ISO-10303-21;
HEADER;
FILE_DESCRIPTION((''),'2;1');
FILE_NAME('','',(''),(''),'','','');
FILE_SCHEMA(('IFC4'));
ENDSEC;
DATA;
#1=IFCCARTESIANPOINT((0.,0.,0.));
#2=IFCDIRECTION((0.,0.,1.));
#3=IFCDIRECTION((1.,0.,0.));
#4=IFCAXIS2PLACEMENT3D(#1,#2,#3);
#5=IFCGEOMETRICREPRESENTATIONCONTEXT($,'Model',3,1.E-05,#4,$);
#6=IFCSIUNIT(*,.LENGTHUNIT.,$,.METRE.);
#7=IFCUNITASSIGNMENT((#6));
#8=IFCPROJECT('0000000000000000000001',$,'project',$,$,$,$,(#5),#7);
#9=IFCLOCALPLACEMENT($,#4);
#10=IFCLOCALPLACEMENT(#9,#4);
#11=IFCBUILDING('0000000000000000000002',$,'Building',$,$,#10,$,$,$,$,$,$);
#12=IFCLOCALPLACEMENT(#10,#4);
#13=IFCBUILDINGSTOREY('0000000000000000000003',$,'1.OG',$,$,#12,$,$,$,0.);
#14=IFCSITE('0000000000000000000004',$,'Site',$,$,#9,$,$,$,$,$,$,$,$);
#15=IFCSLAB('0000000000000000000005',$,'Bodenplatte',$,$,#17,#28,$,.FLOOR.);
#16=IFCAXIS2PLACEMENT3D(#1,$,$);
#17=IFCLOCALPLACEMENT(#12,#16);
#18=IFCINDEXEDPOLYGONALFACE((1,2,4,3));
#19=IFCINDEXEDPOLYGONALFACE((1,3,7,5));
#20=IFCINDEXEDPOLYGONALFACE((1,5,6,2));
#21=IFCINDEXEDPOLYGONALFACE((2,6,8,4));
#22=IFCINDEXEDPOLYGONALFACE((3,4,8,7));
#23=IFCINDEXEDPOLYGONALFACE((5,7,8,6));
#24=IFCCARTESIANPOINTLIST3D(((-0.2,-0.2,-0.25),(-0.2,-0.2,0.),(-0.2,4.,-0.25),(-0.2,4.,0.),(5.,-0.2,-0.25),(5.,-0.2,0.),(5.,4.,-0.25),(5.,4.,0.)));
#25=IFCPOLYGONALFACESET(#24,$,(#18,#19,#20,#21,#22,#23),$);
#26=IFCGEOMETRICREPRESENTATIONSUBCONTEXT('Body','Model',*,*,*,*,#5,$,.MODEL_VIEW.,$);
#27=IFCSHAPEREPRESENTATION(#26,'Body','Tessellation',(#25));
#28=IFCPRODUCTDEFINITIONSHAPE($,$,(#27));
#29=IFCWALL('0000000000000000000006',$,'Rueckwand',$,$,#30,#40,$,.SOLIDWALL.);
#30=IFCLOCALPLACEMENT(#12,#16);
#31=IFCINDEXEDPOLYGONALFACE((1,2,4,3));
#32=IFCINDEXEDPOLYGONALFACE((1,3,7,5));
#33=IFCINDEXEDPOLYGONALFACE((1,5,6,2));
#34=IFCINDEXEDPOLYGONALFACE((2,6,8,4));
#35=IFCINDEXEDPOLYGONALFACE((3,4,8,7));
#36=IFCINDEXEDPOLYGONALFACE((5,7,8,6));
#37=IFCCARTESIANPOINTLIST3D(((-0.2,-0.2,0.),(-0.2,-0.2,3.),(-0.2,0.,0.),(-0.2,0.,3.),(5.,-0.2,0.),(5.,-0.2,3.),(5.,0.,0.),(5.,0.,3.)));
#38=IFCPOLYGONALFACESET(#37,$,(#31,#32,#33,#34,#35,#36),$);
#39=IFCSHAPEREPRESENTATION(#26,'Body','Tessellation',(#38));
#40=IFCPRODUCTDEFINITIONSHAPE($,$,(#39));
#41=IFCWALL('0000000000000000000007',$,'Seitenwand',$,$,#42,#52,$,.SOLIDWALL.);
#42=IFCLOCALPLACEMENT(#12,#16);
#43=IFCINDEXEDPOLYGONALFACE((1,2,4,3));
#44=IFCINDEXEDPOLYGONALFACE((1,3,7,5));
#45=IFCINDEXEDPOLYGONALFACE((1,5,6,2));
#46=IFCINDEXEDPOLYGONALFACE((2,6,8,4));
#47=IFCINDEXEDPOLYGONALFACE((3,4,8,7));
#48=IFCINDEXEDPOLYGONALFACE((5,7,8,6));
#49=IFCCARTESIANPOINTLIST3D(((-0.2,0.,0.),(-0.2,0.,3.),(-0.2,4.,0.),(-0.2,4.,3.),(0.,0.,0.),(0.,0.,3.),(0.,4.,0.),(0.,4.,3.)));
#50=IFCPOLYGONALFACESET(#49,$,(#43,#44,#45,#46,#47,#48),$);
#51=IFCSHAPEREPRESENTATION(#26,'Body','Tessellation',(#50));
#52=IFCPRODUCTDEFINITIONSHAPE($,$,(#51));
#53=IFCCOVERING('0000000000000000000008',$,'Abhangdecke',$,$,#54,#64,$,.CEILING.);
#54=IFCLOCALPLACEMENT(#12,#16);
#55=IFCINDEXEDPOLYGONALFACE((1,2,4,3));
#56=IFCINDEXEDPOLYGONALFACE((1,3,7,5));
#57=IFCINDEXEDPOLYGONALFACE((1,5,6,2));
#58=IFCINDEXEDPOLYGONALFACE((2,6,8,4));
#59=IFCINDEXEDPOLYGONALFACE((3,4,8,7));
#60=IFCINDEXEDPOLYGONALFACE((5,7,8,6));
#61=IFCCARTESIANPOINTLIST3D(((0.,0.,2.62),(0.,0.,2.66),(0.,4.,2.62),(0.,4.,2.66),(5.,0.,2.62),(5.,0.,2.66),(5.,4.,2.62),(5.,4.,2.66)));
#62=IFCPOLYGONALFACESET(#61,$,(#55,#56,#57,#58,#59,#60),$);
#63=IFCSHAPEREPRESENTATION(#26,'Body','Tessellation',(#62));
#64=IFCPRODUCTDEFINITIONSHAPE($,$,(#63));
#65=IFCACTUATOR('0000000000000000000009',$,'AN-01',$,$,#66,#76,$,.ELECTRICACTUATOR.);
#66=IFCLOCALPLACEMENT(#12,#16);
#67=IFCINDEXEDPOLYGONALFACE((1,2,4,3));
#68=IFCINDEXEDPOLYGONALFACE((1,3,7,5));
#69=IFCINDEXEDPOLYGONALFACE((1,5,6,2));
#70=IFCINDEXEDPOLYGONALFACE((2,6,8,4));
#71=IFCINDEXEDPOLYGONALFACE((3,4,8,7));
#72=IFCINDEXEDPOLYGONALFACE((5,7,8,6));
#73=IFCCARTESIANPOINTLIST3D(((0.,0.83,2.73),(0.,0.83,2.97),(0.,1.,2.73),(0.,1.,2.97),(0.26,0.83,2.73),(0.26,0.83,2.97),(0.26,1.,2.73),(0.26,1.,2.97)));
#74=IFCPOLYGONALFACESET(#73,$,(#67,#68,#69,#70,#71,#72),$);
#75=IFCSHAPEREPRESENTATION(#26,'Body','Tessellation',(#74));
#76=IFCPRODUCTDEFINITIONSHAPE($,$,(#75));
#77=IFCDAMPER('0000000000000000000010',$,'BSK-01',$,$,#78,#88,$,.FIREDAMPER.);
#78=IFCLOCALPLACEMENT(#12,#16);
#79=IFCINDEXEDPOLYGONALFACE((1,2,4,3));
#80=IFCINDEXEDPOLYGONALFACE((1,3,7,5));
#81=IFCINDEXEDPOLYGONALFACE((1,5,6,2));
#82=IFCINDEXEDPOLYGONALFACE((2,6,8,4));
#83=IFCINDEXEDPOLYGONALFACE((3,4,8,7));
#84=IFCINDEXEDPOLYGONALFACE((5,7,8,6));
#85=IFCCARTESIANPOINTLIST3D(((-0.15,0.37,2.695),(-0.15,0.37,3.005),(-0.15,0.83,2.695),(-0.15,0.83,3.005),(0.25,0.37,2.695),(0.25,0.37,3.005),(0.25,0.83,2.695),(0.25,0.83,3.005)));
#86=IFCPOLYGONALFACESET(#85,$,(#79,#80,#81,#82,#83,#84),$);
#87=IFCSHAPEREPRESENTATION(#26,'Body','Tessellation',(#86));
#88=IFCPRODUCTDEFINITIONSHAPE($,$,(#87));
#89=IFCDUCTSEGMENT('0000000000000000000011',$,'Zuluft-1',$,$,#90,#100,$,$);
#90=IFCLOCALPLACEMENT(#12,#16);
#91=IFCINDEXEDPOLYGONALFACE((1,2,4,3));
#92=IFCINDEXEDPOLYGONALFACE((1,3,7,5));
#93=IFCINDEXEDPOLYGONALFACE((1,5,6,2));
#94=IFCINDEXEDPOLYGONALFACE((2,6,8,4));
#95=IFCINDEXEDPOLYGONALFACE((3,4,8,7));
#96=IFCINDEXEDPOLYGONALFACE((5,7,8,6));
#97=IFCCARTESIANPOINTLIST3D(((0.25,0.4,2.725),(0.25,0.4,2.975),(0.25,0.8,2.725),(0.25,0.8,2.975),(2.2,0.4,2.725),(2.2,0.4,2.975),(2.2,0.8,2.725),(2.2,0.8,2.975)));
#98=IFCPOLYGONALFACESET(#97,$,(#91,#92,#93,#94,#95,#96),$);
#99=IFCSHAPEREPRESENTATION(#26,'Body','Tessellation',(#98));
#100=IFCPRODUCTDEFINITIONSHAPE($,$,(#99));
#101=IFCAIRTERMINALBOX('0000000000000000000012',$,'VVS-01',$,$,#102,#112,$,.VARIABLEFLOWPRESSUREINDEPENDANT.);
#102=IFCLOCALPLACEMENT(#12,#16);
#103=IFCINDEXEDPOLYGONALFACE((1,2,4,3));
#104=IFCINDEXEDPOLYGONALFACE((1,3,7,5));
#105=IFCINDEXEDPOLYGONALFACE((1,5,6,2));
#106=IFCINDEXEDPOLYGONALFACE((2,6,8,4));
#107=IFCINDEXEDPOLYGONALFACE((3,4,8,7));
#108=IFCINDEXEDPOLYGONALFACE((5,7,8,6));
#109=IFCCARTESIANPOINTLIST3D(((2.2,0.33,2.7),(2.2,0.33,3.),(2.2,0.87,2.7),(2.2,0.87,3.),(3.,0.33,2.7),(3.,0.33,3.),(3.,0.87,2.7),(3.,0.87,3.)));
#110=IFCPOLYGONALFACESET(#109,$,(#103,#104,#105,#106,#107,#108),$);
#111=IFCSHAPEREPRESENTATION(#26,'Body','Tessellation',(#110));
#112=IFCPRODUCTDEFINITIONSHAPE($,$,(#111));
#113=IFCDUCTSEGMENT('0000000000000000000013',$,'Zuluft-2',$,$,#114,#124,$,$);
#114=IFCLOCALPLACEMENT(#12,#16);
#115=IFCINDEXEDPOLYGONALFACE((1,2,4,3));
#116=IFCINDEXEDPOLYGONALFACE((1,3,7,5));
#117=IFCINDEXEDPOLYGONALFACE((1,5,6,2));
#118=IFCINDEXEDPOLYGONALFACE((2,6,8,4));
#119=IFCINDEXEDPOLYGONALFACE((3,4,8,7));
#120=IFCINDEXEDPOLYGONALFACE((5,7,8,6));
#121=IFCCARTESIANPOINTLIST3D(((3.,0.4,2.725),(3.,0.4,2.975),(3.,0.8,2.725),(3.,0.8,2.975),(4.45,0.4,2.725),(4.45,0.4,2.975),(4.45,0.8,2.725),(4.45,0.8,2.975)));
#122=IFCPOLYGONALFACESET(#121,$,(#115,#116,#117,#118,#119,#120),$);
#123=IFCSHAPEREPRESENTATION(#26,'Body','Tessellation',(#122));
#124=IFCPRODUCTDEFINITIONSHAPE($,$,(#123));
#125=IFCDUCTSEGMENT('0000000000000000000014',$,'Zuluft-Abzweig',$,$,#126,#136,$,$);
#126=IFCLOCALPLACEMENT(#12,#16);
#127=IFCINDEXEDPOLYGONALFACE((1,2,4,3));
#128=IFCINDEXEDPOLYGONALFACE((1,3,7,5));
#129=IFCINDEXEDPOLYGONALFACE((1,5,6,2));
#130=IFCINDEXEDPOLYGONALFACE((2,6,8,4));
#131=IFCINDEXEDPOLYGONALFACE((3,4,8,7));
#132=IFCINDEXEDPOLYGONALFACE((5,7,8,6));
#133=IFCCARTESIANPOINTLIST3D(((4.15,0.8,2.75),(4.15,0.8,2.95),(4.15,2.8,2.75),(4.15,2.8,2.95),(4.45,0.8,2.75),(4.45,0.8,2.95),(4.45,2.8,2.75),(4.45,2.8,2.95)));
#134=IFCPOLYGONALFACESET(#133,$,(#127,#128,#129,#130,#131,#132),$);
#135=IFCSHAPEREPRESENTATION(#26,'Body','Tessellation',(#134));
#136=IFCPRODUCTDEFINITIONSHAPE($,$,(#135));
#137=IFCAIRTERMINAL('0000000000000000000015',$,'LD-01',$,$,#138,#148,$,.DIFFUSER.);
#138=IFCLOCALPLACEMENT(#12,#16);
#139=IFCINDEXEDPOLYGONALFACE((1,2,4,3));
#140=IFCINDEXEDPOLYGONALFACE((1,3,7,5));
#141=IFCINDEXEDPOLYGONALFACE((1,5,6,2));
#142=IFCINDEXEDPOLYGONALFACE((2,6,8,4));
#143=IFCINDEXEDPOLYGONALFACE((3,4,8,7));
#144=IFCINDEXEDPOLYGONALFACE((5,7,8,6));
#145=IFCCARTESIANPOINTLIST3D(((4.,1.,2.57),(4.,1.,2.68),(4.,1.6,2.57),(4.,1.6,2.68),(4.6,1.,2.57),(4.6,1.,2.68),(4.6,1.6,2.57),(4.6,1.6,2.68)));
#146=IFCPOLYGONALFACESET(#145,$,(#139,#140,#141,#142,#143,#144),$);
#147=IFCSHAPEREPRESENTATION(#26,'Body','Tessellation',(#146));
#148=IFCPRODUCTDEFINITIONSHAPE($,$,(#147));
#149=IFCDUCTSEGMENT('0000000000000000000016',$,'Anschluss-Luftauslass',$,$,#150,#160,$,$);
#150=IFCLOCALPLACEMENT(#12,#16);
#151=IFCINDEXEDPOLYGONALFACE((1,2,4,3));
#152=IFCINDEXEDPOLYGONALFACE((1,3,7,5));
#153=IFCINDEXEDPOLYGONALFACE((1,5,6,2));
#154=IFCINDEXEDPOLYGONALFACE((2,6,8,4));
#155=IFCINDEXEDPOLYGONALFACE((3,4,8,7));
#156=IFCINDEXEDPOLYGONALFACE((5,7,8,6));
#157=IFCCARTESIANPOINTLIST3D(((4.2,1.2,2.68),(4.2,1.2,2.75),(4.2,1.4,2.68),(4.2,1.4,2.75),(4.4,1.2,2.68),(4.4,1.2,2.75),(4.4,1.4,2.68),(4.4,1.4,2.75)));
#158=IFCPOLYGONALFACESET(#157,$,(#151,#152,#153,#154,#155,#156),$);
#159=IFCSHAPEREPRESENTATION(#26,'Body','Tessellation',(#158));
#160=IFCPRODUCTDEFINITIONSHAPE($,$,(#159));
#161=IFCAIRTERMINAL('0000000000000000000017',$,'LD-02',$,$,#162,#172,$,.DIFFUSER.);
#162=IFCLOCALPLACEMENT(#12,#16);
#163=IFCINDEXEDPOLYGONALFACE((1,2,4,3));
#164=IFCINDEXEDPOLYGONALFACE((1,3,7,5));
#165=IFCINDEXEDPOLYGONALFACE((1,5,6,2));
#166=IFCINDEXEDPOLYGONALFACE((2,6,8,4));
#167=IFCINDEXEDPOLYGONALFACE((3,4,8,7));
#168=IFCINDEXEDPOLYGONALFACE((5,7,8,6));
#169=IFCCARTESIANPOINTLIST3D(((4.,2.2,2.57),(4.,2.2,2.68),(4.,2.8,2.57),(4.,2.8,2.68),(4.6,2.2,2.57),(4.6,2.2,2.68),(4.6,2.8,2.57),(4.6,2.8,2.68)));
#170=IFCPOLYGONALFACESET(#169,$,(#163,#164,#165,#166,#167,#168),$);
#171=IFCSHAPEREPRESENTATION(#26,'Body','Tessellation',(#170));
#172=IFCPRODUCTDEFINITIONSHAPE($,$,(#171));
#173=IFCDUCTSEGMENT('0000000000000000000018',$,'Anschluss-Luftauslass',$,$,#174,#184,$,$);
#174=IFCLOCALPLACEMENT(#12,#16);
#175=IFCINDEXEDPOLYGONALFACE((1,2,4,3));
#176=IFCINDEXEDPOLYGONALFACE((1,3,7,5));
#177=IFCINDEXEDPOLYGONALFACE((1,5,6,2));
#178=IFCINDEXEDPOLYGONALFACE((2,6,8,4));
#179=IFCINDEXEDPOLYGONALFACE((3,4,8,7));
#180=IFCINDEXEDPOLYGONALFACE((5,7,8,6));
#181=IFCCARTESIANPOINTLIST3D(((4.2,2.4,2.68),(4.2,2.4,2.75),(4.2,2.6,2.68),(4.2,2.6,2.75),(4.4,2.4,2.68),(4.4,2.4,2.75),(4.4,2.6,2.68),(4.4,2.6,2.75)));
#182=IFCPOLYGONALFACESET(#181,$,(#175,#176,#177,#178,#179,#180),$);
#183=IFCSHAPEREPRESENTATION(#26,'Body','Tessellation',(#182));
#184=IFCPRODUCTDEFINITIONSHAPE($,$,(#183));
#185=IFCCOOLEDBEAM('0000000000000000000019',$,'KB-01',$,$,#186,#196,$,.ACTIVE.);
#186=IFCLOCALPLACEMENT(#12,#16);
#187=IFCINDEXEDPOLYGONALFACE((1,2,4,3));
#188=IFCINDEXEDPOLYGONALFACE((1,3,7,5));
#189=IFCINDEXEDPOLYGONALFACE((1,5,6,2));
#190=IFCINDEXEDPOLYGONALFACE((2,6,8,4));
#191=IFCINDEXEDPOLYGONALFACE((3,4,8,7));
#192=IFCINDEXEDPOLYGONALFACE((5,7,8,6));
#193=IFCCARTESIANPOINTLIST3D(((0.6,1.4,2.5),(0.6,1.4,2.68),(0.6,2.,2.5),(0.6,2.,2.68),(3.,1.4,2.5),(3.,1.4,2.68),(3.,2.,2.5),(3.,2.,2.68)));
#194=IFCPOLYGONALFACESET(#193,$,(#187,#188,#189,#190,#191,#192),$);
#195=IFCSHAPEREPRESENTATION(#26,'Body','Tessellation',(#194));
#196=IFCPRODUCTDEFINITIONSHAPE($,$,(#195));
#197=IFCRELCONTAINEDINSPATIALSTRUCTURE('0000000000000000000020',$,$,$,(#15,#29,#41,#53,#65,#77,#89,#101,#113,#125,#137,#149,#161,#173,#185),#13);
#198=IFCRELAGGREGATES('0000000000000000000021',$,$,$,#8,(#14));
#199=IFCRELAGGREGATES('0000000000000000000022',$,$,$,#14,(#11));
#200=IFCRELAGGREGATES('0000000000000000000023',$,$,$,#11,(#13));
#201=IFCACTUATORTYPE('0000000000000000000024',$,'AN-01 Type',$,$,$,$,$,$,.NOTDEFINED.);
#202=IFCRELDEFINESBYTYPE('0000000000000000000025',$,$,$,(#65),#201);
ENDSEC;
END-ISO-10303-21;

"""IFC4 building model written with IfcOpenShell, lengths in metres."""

from ifc_helpers import new_model, si_unit, frame, origin_with_axes, place, context, subcontext, project, spatial, polyline, outline, extrude, type_object, element, save


model = new_model("IFC4")

# Units and contexts
model_context = context("Model", 3, precision=1e-05, world=origin_with_axes())
body_context = subcontext(model_context, "Body", "Model", "MODEL_VIEW")
ifc_project = project(units=[si_unit("LENGTHUNIT", "METRE")], contexts=[model_context])

# Site, building, storey
site_placement = place(None, origin_with_axes())
site = spatial("IfcSite", under=ifc_project, at=site_placement, Name="Site")
building_placement = place(site_placement, origin_with_axes())
building = spatial("IfcBuilding", under=site, at=building_placement, Name="Building")
storey_placement = place(building_placement, origin_with_axes())
storey = spatial("IfcBuildingStorey", under=building, at=storey_placement, Name="1.OG", Elevation=0.0)

# Slab
slab_placement = place(storey_placement, frame((0.0, 0.0, -0.25), z_axis=(0.0, 0.0, 1.0), x_axis=(1.0, 0.0, 0.0)))
element("IfcSlab", 1, at=slab_placement, inside=storey, Name="Bodenplatte", PredefinedType="FLOOR", context=body_context, shape_type="SweptSolid", body=[
    extrude(outline(polyline([(-0.2, -0.2, 0.0), (5.0, -0.2, 0.0), (5.0, 4.0, 0.0), (-0.2, 4.0, 0.0), (-0.2, -0.2, 0.0)])), origin_with_axes(), (0.0, 0.0, 1.0), 0.25),
])

# Walls
wall_1_placement = place(storey_placement, frame((-0.2, -0.2, 0.0), z_axis=(0.0, 0.0, 1.0), x_axis=(1.0, 0.0, 0.0)))
element("IfcWall", 2, at=wall_1_placement, inside=storey, Name="Rueckwand", PredefinedType="SOLIDWALL", context=body_context, shape_type="SweptSolid", body=[
    extrude(outline(polyline([(0.0, 0.0, 0.0), (5.2, 0.0, 0.0), (5.2, 0.2, 0.0), (0.0, 0.2, 0.0), (0.0, 0.0, 0.0)])), origin_with_axes(), (0.0, 0.0, 1.0), 3.0),
])
wall_2_placement = place(storey_placement, frame((0.0, 0.0, 0.0), z_axis=(0.0, 0.0, 1.0), x_axis=(0.0, 1.0, 0.0)))
element("IfcWall", 3, at=wall_2_placement, inside=storey, Name="Seitenwand", PredefinedType="SOLIDWALL", context=body_context, shape_type="SweptSolid", body=[
    extrude(outline(polyline([(0.0, 0.0, 0.0), (4.0, 0.0, 0.0), (4.0, 0.2, 0.0), (0.0, 0.2, 0.0), (0.0, 0.0, 0.0)])), origin_with_axes(), (0.0, 0.0, 1.0), 3.0),
])

# Covering
covering_placement = place(storey_placement, frame((0.0, 0.0, 2.62), z_axis=(0.0, 0.0, 1.0), x_axis=(1.0, 0.0, 0.0)))
element("IfcCovering", 4, at=covering_placement, inside=storey, Name="Abhangdecke", PredefinedType="CEILING", context=body_context, shape_type="SweptSolid", body=[
    extrude(outline(polyline([(0.0, 0.0, 0.0), (5.0, 0.0, 0.0), (5.0, 4.0, 0.0), (0.0, 4.0, 0.0), (0.0, 0.0, 0.0)])), origin_with_axes(), (0.0, 0.0, 1.0), 0.04),
])

# Actuator
actuator_type = type_object("IfcActuatorType", Name="AN-01 Type", PredefinedType="NOTDEFINED")
actuator_placement = place(storey_placement, origin_with_axes())
element("IfcActuator", 5, at=actuator_placement, inside=storey, type_object=actuator_type, Name="AN-01", PredefinedType="ELECTRICACTUATOR", context=body_context, shape_type="SweptSolid", body=[
    extrude(outline(polyline([(0.0, 0.83, 0.0), (0.26, 0.83, 0.0), (0.26, 1.0, 0.0), (0.0, 1.0, 0.0), (0.0, 0.83, 0.0)])), frame((0.0, 0.0, 2.73), z_axis=(0.0, 0.0, 1.0), x_axis=(1.0, 0.0, 0.0)), (0.0, 0.0, 1.0), 0.24),
])

# Damper
damper_placement = place(storey_placement, origin_with_axes())
element("IfcDamper", 6, at=damper_placement, inside=storey, Name="BSK-01", PredefinedType="FIREDAMPER", context=body_context, shape_type="SweptSolid", body=[
    extrude(outline(polyline([(-0.15, 0.37, 0.0), (0.25, 0.37, 0.0), (0.25, 0.83, 0.0), (-0.15, 0.83, 0.0), (-0.15, 0.37, 0.0)])), frame((0.0, 0.0, 2.695), z_axis=(0.0, 0.0, 1.0), x_axis=(1.0, 0.0, 0.0)), (0.0, 0.0, 1.0), 0.31),
])

# Duct segment
duct_segment_1_placement = place(storey_placement, origin_with_axes())
element("IfcDuctSegment", 7, at=duct_segment_1_placement, inside=storey, Name="Zuluft-1", context=body_context, shape_type="SweptSolid", body=[
    extrude(outline(polyline([(-0.2, -0.125, 0.0), (0.2, -0.125, 0.0), (0.2, 0.125, 0.0), (-0.2, 0.125, 0.0), (-0.2, -0.125, 0.0)])), frame((0.25, 0.6, 2.85), z_axis=(1.0, 0.0, 0.0), x_axis=(0.0, 1.0, 0.0)), (0.0, 0.0, 1.0), 1.95),
])

# Air terminal box
air_terminal_box_placement = place(storey_placement, origin_with_axes())
element("IfcAirTerminalBox", 8, at=air_terminal_box_placement, inside=storey, Name="VVS-01", PredefinedType="VARIABLEFLOWPRESSUREINDEPENDANT", context=body_context, shape_type="SweptSolid", body=[
    extrude(outline(polyline([(2.2, 0.33, 0.0), (3.0, 0.33, 0.0), (3.0, 0.87, 0.0), (2.2, 0.87, 0.0), (2.2, 0.33, 0.0)])), frame((0.0, 0.0, 2.7), z_axis=(0.0, 0.0, 1.0), x_axis=(1.0, 0.0, 0.0)), (0.0, 0.0, 1.0), 0.3),
])

# Duct segments
duct_segment_2_placement = place(storey_placement, origin_with_axes())
element("IfcDuctSegment", 9, at=duct_segment_2_placement, inside=storey, Name="Zuluft-2", context=body_context, shape_type="SweptSolid", body=[
    extrude(outline(polyline([(-0.2, -0.125, 0.0), (0.2, -0.125, 0.0), (0.2, 0.125, 0.0), (-0.2, 0.125, 0.0), (-0.2, -0.125, 0.0)])), frame((3.0, 0.6, 2.85), z_axis=(1.0, 0.0, 0.0), x_axis=(0.0, 1.0, 0.0)), (0.0, 0.0, 1.0), 1.45),
])
duct_segment_3_placement = place(storey_placement, origin_with_axes())
element("IfcDuctSegment", 10, at=duct_segment_3_placement, inside=storey, Name="Zuluft-Abzweig", context=body_context, shape_type="SweptSolid", body=[
    extrude(outline(polyline([(-0.15, -0.1, 0.0), (0.15, -0.1, 0.0), (0.15, 0.1, 0.0), (-0.15, 0.1, 0.0), (-0.15, -0.1, 0.0)])), frame((4.3, 0.8, 2.85), z_axis=(0.0, 1.0, 0.0), x_axis=(-1.0, 0.0, 0.0)), (0.0, 0.0, 1.0), 2.0),
])

# Air terminal
air_terminal_1_placement = place(storey_placement, origin_with_axes())
element("IfcAirTerminal", 11, at=air_terminal_1_placement, inside=storey, Name="LD-01", PredefinedType="DIFFUSER", context=body_context, shape_type="SweptSolid", body=[
    extrude(outline(polyline([(4.0, 1.0, 0.0), (4.6, 1.0, 0.0), (4.6, 1.6, 0.0), (4.0, 1.6, 0.0), (4.0, 1.0, 0.0)])), frame((0.0, 0.0, 2.57), z_axis=(0.0, 0.0, 1.0), x_axis=(1.0, 0.0, 0.0)), (0.0, 0.0, 1.0), 0.11),
])

# Duct segment
duct_segment_4_placement = place(storey_placement, origin_with_axes())
element("IfcDuctSegment", 12, at=duct_segment_4_placement, inside=storey, Name="Anschluss-Luftauslass", context=body_context, shape_type="SweptSolid", body=[
    extrude(outline(polyline([(-0.1, -0.1, 0.0), (0.1, -0.1, 0.0), (0.1, 0.1, 0.0), (-0.1, 0.1, 0.0), (-0.1, -0.1, 0.0)])), frame((4.3, 1.3, 2.68), z_axis=(0.0, 0.0, 1.0), x_axis=(1.0, 0.0, 0.0)), (0.0, 0.0, 1.0), 0.07),
])

# Air terminal
air_terminal_2_placement = place(storey_placement, origin_with_axes())
element("IfcAirTerminal", 13, at=air_terminal_2_placement, inside=storey, Name="LD-02", PredefinedType="DIFFUSER", context=body_context, shape_type="SweptSolid", body=[
    extrude(outline(polyline([(4.0, 2.2, 0.0), (4.6, 2.2, 0.0), (4.6, 2.8, 0.0), (4.0, 2.8, 0.0), (4.0, 2.2, 0.0)])), frame((0.0, 0.0, 2.57), z_axis=(0.0, 0.0, 1.0), x_axis=(1.0, 0.0, 0.0)), (0.0, 0.0, 1.0), 0.11),
])

# Duct segment
duct_segment_5_placement = place(storey_placement, origin_with_axes())
element("IfcDuctSegment", 14, at=duct_segment_5_placement, inside=storey, Name="Anschluss-Luftauslass", context=body_context, shape_type="SweptSolid", body=[
    extrude(outline(polyline([(-0.1, -0.1, 0.0), (0.1, -0.1, 0.0), (0.1, 0.1, 0.0), (-0.1, 0.1, 0.0), (-0.1, -0.1, 0.0)])), frame((4.3, 2.5, 2.68), z_axis=(0.0, 0.0, 1.0), x_axis=(1.0, 0.0, 0.0)), (0.0, 0.0, 1.0), 0.07),
])

# Cooled beam
cooled_beam_placement = place(storey_placement, origin_with_axes())
element("IfcCooledBeam", 15, at=cooled_beam_placement, inside=storey, Name="KB-01", PredefinedType="ACTIVE", context=body_context, shape_type="SweptSolid", body=[
    extrude(outline(polyline([(0.6, 1.4, 0.0), (3.0, 1.4, 0.0), (3.0, 2.0, 0.0), (0.6, 2.0, 0.0), (0.6, 1.4, 0.0)])), frame((0.0, 0.0, 2.5), z_axis=(0.0, 0.0, 1.0), x_axis=(1.0, 0.0, 0.0)), (0.0, 0.0, 1.0), 0.18),
])

save(model, "model.ifc")
